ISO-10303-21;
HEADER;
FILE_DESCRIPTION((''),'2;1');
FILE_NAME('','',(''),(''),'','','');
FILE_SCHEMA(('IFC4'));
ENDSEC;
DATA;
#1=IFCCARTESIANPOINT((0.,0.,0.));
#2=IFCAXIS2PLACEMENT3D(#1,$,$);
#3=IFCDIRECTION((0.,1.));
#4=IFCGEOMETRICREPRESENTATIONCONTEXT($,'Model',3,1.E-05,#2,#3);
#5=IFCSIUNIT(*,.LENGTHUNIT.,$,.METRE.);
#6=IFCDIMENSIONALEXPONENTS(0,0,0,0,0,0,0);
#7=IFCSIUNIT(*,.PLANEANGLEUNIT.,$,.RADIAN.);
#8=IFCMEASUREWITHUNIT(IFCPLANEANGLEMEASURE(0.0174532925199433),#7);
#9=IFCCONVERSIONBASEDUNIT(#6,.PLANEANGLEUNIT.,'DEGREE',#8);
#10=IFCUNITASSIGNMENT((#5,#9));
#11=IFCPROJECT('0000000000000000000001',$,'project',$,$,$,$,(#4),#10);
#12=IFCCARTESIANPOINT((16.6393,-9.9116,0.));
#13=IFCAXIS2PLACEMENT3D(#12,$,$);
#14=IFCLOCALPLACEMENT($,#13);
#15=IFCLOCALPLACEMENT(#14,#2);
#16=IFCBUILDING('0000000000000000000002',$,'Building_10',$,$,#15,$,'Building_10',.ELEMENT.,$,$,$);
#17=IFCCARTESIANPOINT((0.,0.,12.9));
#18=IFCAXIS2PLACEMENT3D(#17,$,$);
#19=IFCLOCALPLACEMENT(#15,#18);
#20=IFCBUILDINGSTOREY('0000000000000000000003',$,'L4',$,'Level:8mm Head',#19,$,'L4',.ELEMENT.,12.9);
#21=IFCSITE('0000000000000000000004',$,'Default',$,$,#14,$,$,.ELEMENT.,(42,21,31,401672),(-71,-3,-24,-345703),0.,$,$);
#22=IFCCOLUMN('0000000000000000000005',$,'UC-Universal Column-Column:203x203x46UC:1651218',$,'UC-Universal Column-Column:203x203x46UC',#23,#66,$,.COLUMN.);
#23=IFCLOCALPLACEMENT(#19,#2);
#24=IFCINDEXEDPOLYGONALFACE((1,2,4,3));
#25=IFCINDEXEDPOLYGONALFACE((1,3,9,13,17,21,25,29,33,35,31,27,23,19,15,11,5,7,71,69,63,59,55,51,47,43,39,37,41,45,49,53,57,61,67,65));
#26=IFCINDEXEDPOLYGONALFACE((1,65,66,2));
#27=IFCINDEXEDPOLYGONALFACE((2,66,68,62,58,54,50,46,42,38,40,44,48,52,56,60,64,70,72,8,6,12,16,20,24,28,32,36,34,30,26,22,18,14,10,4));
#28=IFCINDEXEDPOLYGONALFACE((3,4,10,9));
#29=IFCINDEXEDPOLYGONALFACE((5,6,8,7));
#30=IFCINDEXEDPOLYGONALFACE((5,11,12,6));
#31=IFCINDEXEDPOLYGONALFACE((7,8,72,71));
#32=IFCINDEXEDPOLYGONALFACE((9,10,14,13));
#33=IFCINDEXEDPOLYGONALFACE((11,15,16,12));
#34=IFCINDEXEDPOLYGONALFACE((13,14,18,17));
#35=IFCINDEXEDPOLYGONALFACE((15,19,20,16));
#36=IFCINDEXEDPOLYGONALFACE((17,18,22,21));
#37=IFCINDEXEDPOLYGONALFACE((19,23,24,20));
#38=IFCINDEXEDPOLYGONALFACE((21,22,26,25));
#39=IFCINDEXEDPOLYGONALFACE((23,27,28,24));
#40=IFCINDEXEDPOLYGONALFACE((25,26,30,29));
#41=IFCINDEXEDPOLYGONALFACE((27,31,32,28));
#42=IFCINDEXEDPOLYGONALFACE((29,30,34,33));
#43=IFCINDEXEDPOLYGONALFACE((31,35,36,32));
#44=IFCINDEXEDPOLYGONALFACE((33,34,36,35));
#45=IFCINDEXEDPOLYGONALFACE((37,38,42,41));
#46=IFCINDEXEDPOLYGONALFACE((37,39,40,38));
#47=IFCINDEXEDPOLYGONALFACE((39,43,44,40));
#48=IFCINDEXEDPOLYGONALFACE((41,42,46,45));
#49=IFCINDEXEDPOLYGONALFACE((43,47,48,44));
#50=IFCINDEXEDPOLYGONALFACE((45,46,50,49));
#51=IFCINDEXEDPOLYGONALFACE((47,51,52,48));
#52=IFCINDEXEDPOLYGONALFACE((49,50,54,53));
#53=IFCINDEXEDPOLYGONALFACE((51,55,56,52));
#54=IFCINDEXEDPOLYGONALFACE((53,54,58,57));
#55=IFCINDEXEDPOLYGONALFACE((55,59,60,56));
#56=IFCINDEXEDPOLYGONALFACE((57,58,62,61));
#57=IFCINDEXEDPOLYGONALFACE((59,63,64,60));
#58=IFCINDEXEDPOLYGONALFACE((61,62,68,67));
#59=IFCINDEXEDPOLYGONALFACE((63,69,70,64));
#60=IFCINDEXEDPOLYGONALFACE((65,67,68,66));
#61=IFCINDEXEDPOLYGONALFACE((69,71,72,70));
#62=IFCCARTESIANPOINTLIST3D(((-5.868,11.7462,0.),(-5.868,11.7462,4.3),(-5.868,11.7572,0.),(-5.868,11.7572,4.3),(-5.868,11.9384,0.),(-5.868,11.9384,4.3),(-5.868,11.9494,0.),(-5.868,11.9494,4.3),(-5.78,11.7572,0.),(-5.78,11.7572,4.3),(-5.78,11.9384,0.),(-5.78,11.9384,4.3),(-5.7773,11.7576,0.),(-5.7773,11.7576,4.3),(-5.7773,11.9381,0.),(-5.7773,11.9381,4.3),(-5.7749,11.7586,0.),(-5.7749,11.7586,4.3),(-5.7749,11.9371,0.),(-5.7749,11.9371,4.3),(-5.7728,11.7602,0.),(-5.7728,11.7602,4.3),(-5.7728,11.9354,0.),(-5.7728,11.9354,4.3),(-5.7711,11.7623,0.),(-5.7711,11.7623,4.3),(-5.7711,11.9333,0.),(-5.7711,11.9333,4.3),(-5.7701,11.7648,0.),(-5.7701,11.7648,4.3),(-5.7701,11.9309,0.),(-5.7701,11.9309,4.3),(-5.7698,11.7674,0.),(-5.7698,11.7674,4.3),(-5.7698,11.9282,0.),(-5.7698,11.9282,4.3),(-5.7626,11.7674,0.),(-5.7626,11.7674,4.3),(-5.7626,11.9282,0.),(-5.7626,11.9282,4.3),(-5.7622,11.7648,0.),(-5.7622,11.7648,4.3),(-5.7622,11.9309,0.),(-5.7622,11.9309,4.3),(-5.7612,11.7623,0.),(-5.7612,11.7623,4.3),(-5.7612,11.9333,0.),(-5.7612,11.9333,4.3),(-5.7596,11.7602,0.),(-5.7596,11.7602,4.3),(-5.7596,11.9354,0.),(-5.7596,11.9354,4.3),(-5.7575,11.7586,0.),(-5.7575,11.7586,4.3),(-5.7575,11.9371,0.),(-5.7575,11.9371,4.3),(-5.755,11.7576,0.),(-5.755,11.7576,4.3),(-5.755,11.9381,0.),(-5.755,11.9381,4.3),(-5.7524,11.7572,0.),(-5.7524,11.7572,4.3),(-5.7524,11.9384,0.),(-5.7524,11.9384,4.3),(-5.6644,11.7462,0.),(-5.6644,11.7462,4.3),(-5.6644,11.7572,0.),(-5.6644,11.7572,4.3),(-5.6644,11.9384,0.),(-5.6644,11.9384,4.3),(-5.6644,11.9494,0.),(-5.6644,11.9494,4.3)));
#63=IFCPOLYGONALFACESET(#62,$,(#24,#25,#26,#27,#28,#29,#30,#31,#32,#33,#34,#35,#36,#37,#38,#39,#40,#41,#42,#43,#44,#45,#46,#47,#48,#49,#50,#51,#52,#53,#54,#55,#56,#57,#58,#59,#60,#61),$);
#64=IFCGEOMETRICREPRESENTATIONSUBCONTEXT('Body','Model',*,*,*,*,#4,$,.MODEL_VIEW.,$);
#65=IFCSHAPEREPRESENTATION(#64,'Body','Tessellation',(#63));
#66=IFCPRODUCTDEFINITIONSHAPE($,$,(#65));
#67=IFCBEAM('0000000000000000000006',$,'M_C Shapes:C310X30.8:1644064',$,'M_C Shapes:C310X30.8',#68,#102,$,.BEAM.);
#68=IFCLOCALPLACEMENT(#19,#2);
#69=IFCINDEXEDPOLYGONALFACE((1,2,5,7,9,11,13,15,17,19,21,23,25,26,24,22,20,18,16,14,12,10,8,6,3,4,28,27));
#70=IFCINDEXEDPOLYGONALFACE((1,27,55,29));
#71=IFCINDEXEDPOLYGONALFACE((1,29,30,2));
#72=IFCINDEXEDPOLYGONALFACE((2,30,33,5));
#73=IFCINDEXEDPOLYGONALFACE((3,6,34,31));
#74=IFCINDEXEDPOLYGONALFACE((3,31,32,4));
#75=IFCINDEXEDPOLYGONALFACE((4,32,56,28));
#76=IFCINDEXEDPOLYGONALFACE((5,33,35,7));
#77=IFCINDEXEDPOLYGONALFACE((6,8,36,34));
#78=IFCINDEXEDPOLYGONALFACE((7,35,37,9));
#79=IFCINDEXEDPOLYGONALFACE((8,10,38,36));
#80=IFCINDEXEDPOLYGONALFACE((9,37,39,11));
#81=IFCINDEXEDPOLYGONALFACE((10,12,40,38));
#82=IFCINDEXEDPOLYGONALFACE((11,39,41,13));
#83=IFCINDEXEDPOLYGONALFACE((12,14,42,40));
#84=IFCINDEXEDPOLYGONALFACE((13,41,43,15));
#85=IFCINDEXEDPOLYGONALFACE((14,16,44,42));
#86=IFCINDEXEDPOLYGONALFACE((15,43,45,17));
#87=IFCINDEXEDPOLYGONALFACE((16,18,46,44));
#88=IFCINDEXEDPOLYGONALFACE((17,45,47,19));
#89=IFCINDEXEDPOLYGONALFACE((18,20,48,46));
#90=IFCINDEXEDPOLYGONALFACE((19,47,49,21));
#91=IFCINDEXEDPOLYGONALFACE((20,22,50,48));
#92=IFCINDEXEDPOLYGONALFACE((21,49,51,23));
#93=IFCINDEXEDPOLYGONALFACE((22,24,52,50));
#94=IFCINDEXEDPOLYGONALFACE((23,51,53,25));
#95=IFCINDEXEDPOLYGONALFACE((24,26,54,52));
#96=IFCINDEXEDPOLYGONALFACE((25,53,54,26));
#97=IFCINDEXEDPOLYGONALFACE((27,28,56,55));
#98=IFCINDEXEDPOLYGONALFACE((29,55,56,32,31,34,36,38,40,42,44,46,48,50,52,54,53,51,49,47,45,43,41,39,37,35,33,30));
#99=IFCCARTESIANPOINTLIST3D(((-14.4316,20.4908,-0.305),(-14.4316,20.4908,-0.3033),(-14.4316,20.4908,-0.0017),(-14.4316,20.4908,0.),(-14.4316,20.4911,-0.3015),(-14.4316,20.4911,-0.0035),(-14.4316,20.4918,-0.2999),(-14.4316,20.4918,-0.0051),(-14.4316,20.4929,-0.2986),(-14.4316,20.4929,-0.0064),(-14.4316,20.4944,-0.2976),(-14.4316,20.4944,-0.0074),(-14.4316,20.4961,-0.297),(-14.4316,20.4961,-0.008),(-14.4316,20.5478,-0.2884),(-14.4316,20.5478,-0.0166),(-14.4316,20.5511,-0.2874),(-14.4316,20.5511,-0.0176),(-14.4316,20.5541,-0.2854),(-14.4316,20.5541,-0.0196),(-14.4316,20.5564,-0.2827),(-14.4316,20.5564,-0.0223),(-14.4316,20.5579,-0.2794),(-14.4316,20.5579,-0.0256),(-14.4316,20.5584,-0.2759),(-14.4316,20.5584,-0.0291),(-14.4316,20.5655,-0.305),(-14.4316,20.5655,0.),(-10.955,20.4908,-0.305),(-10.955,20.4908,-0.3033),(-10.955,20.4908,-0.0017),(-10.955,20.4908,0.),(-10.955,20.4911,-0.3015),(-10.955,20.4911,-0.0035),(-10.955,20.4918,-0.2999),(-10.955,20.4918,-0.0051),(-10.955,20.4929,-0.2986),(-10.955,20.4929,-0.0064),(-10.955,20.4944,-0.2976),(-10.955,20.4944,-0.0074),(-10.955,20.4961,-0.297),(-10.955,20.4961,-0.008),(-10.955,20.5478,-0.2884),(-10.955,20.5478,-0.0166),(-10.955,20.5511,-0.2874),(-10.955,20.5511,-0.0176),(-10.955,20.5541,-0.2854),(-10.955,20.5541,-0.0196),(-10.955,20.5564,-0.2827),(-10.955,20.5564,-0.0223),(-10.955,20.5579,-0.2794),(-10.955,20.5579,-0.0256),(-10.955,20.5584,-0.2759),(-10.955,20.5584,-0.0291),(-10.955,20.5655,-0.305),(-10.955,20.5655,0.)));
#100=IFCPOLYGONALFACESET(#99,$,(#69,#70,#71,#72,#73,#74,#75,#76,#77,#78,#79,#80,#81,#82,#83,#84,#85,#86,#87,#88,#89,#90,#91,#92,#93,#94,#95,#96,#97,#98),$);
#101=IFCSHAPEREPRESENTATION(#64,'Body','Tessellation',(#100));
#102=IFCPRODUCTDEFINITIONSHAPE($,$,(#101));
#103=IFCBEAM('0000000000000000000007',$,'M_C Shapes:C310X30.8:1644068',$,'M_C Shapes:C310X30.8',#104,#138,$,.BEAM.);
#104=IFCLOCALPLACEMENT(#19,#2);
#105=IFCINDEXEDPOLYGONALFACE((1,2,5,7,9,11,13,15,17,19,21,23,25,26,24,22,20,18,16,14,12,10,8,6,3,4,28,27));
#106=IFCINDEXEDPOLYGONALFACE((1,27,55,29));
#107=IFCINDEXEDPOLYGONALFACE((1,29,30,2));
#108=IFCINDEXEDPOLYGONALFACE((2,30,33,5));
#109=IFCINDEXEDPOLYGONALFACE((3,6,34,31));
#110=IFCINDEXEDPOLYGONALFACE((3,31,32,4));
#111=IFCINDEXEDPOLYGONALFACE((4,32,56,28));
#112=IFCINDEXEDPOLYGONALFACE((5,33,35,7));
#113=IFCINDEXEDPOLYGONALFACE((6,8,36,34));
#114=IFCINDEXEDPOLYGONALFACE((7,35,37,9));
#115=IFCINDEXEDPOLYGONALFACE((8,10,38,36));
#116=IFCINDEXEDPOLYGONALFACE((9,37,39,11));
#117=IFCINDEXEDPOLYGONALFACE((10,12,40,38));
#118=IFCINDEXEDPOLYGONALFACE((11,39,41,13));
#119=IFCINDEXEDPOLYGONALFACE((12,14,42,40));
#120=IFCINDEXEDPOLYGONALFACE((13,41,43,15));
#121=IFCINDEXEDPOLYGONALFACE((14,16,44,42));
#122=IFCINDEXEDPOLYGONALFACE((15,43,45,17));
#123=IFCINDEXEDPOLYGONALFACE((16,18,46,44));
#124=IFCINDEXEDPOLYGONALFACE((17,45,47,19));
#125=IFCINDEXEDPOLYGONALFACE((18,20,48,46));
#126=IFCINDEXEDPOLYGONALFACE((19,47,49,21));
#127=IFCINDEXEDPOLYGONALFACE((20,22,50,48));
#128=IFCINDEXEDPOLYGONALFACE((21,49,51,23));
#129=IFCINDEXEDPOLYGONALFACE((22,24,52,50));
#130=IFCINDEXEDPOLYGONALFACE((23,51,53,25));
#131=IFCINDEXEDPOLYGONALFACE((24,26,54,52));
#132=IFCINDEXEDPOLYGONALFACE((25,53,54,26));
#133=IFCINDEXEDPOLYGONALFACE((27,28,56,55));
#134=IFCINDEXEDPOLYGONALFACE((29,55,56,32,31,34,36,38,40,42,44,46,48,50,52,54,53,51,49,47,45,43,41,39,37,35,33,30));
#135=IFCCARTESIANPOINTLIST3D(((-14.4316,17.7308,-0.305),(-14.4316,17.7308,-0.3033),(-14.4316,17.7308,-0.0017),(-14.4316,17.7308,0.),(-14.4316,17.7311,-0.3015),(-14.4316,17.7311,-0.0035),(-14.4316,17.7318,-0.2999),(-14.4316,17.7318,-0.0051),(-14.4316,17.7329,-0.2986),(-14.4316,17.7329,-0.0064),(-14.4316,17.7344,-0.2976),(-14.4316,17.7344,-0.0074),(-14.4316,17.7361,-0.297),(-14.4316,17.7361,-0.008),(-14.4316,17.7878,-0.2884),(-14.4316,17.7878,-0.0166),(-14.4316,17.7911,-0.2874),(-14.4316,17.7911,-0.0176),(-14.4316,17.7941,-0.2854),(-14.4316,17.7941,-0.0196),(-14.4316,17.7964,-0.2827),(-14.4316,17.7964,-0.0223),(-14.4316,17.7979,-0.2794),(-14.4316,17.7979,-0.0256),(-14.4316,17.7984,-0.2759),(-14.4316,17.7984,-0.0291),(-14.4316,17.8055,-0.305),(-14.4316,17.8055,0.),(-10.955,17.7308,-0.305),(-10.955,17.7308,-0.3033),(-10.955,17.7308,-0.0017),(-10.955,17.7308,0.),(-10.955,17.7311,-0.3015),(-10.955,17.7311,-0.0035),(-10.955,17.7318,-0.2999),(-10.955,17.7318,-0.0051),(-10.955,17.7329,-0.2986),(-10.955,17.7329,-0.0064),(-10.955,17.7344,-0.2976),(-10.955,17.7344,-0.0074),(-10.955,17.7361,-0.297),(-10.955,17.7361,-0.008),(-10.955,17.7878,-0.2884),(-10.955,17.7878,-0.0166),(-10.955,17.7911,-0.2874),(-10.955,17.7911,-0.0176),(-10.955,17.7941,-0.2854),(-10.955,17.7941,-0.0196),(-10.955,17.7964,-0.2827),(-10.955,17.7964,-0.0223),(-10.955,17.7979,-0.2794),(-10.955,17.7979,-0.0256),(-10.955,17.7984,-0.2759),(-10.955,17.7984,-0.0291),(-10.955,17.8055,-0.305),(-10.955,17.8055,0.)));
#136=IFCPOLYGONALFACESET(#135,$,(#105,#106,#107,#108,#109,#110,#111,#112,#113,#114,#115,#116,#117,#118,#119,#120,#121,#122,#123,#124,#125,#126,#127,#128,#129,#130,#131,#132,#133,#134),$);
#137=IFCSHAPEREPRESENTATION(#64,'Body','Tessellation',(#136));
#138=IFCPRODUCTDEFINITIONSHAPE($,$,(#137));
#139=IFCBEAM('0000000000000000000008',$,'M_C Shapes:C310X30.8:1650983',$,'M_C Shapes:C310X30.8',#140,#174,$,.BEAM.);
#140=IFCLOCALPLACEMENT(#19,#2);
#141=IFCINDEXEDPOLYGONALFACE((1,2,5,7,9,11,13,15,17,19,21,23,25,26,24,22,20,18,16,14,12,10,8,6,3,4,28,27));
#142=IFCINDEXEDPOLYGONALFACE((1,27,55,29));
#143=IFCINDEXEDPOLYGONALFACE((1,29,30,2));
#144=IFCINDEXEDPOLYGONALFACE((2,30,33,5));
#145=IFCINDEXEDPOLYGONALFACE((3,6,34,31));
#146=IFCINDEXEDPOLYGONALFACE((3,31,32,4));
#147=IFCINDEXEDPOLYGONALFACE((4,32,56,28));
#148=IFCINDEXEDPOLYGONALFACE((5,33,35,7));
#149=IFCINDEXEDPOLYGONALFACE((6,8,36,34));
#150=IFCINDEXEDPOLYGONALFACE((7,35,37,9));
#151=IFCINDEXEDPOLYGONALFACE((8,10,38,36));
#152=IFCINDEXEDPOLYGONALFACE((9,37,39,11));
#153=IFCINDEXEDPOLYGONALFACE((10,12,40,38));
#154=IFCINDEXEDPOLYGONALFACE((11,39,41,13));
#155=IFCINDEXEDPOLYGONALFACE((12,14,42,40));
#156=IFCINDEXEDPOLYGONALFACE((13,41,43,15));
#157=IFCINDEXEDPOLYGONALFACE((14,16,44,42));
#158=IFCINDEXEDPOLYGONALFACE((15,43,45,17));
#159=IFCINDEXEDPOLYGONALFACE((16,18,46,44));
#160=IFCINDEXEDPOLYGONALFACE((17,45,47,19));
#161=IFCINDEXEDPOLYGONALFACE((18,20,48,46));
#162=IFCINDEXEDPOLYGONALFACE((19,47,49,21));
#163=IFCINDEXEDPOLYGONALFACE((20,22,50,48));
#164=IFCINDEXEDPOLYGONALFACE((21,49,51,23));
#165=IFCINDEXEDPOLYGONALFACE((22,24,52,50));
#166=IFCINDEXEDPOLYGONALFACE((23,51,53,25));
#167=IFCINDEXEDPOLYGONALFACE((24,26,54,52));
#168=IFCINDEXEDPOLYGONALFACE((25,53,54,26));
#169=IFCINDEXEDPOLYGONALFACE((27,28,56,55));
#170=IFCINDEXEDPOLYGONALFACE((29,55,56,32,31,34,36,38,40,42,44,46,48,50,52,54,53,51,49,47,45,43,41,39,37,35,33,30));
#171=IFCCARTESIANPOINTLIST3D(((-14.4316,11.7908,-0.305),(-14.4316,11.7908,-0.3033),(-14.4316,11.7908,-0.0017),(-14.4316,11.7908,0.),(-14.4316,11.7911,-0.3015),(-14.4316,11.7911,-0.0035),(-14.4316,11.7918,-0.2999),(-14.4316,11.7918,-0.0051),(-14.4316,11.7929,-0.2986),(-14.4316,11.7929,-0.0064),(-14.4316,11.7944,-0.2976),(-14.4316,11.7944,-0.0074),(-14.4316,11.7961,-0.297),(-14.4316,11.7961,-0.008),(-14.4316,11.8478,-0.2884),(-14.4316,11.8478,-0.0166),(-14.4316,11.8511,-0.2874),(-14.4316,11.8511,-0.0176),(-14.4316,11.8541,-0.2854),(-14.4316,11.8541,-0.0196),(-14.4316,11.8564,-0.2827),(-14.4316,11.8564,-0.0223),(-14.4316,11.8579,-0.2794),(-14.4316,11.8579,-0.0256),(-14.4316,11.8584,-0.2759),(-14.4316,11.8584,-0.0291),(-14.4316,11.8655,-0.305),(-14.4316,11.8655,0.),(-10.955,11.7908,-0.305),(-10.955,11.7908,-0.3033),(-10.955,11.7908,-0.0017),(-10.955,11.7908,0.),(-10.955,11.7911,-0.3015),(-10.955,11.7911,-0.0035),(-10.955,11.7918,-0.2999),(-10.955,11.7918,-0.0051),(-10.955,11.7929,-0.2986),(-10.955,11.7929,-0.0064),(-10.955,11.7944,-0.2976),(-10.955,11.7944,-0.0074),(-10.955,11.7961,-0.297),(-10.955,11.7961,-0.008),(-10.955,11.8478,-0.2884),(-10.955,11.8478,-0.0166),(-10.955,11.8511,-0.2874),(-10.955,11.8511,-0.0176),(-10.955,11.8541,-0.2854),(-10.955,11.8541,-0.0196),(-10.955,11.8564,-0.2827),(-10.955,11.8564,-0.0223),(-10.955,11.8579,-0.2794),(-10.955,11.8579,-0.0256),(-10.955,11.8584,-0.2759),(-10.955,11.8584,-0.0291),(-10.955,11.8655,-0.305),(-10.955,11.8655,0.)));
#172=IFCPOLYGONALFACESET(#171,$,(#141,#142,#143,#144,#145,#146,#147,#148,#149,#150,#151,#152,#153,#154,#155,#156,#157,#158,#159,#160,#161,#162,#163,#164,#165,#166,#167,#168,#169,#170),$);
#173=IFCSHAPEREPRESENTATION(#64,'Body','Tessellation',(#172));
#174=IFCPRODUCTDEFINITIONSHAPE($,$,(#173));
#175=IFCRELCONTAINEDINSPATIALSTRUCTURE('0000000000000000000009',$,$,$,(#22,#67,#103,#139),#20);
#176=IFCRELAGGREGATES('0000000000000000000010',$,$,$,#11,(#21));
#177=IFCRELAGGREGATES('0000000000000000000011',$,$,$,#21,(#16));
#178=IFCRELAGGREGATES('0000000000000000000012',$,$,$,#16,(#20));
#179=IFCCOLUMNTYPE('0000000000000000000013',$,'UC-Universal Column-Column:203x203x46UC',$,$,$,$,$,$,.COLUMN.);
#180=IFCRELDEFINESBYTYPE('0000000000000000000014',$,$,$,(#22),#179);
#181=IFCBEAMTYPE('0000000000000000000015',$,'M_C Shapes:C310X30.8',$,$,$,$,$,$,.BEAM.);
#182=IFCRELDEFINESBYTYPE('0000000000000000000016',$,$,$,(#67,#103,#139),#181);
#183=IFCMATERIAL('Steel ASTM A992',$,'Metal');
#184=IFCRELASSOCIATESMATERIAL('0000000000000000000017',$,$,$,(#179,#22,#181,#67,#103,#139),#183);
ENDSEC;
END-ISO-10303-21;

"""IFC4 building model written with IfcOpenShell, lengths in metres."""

from ifc_helpers import new_model, entity, si_unit, converted_unit, direction, frame, origin, place, context, subcontext, project, spatial, line, arc, indexed_curve, outline, extrude, source, transform, mapped, material, type_object, type_shapes, element, save


model = new_model("IFC4")

# Units and contexts
model_context = context("Model", 3, precision=1e-05, world=origin(), true_north=direction((0.0, 1.0)))
body_context = subcontext(model_context, "Body", "Model", "MODEL_VIEW")
ifc_project = project(units=[si_unit("LENGTHUNIT", "METRE"), converted_unit("PLANEANGLEUNIT", "DEGREE", entity("IfcPlaneAngleMeasure", 0.0174532925199433), si_unit("PLANEANGLEUNIT", "RADIAN"), dimensions=[0, 0, 0, 0, 0, 0, 0])], contexts=[model_context])

# Site, building, storey
site_placement = place(None, frame((16.6393, -9.9116, 0.0)))
site = spatial("IfcSite", under=ifc_project, at=site_placement, Name="Default", CompositionType="ELEMENT", RefLatitude=(42, 21, 31, 401672), RefLongitude=(-71, -3, -24, -345703), RefElevation=0.0)
building_placement = place(site_placement, origin())
building = spatial("IfcBuilding", under=site, at=building_placement, Name="Building_10", LongName="Building_10", CompositionType="ELEMENT")
storey_placement = place(building_placement, frame((0.0, 0.0, 12.9)))
storey = spatial("IfcBuildingStorey", under=building, at=storey_placement, Name="L4", ObjectType="Level:8mm Head", LongName="L4", CompositionType="ELEMENT", Elevation=12.9)

# Column
ifc_material_1 = material(Name="Steel ASTM A992", Category="Metal")
column_type = type_object("IfcColumnType", Name="UC-Universal Column-Column:203x203x46UC", PredefinedType="COLUMN", material=ifc_material_1)
shared_shape_1 = source(origin(), body_context, "Body", "SweptSolid", [
    extrude(outline(indexed_curve([(-0.1018, -0.1016), (0.1018, -0.1016), (0.1018, -0.0906), (0.0138, -0.0906), (0.0066, -0.0876), (0.0036, -0.0804), (0.0036, 0.0804), (0.0066, 0.0876), (0.0138, 0.0906), (0.1018, 0.0906), (0.1018, 0.1016), (-0.1018, 0.1016), (-0.1018, 0.0906), (-0.0138, 0.0906), (-0.0066, 0.0876), (-0.0036, 0.0804), (-0.0036, -0.0804), (-0.0066, -0.0876), (-0.0138, -0.0906), (-0.1018, -0.0906)], segments=[line(1, 2, 3, 4), arc(4, 5, 6), line(6, 7), arc(7, 8, 9), line(9, 10, 11, 12, 13, 14), arc(14, 15, 16), line(16, 17), arc(17, 18, 19), line(19, 20, 1)], self_intersect=False)), frame((0.0, 0.0, 12.9), z_axis=(0.0, 0.0, 1.0), x_axis=(-1.0, 0.0, 0.0)), (0.0, 0.0, 1.0), 4.3),
])
type_shapes(column_type, [shared_shape_1])
for number, where, name in (
    (1, (-5.7662, 11.8478, -12.9), "UC-Universal Column-Column:203x203x46UC:1651218"),
):
    element("IfcColumn", number, at=place(storey_placement, frame(where)), inside=storey, type_object=column_type, material=ifc_material_1, Name=name, ObjectType="UC-Universal Column-Column:203x203x46UC", PredefinedType="COLUMN", context=body_context, shape_type="MappedRepresentation", body=[
        mapped(shared_shape_1, transform((0.0, 0.0, 0.0), scale=1.0)),
    ])

# Beams
beam_type_1 = type_object("IfcBeamType", Name="M_C Shapes:C310X30.8", PredefinedType="BEAM", material=ifc_material_1)
shared_shape_2 = source(origin(), body_context, "Body", "SweptSolid", [
    extrude(outline(indexed_curve([(-0.0406, -0.1525), (0.0341, -0.1525), (0.0341, -0.1508), (0.0326, -0.1467), (0.0288, -0.1445), (-0.0228, -0.1359), (-0.0305, -0.1316), (-0.0335, -0.1234), (-0.0335, 0.1234), (-0.0305, 0.1316), (-0.0228, 0.1359), (0.0288, 0.1445), (0.0326, 0.1467), (0.0341, 0.1508), (0.0341, 0.1525), (-0.0406, 0.1525)], segments=[line(1, 2, 3), arc(3, 4, 5), line(5, 6), arc(6, 7, 8), line(8, 9), arc(9, 10, 11), line(11, 12), arc(12, 13, 14), line(14, 15, 16, 1)], self_intersect=False)), frame((-1.7383, -0.0229, 0.0), z_axis=(1.0, 0.0, 0.0), x_axis=(0.0, -1.0, 0.0)), (0.0, 0.0, 1.0), 3.4766),
])
type_shapes(beam_type_1, [shared_shape_2])
for number, where, name in (
    (2, (-12.6933, 20.5478, -0.1525), "M_C Shapes:C310X30.8:1644064"),
    (3, (-12.6933, 17.7878, -0.1525), "M_C Shapes:C310X30.8:1644068"),
    (4, (-12.6933, 11.8478, -0.1525), "M_C Shapes:C310X30.8:1650983"),
):
    element("IfcBeam", number, at=place(storey_placement, frame(where)), inside=storey, type_object=beam_type_1, material=ifc_material_1, Name=name, ObjectType="M_C Shapes:C310X30.8", PredefinedType="BEAM", context=body_context, shape_type="MappedRepresentation", body=[
        mapped(shared_shape_2, transform((0.0, 0.0, 0.0), scale=1.0)),
    ])

save(model, "model.ifc")
